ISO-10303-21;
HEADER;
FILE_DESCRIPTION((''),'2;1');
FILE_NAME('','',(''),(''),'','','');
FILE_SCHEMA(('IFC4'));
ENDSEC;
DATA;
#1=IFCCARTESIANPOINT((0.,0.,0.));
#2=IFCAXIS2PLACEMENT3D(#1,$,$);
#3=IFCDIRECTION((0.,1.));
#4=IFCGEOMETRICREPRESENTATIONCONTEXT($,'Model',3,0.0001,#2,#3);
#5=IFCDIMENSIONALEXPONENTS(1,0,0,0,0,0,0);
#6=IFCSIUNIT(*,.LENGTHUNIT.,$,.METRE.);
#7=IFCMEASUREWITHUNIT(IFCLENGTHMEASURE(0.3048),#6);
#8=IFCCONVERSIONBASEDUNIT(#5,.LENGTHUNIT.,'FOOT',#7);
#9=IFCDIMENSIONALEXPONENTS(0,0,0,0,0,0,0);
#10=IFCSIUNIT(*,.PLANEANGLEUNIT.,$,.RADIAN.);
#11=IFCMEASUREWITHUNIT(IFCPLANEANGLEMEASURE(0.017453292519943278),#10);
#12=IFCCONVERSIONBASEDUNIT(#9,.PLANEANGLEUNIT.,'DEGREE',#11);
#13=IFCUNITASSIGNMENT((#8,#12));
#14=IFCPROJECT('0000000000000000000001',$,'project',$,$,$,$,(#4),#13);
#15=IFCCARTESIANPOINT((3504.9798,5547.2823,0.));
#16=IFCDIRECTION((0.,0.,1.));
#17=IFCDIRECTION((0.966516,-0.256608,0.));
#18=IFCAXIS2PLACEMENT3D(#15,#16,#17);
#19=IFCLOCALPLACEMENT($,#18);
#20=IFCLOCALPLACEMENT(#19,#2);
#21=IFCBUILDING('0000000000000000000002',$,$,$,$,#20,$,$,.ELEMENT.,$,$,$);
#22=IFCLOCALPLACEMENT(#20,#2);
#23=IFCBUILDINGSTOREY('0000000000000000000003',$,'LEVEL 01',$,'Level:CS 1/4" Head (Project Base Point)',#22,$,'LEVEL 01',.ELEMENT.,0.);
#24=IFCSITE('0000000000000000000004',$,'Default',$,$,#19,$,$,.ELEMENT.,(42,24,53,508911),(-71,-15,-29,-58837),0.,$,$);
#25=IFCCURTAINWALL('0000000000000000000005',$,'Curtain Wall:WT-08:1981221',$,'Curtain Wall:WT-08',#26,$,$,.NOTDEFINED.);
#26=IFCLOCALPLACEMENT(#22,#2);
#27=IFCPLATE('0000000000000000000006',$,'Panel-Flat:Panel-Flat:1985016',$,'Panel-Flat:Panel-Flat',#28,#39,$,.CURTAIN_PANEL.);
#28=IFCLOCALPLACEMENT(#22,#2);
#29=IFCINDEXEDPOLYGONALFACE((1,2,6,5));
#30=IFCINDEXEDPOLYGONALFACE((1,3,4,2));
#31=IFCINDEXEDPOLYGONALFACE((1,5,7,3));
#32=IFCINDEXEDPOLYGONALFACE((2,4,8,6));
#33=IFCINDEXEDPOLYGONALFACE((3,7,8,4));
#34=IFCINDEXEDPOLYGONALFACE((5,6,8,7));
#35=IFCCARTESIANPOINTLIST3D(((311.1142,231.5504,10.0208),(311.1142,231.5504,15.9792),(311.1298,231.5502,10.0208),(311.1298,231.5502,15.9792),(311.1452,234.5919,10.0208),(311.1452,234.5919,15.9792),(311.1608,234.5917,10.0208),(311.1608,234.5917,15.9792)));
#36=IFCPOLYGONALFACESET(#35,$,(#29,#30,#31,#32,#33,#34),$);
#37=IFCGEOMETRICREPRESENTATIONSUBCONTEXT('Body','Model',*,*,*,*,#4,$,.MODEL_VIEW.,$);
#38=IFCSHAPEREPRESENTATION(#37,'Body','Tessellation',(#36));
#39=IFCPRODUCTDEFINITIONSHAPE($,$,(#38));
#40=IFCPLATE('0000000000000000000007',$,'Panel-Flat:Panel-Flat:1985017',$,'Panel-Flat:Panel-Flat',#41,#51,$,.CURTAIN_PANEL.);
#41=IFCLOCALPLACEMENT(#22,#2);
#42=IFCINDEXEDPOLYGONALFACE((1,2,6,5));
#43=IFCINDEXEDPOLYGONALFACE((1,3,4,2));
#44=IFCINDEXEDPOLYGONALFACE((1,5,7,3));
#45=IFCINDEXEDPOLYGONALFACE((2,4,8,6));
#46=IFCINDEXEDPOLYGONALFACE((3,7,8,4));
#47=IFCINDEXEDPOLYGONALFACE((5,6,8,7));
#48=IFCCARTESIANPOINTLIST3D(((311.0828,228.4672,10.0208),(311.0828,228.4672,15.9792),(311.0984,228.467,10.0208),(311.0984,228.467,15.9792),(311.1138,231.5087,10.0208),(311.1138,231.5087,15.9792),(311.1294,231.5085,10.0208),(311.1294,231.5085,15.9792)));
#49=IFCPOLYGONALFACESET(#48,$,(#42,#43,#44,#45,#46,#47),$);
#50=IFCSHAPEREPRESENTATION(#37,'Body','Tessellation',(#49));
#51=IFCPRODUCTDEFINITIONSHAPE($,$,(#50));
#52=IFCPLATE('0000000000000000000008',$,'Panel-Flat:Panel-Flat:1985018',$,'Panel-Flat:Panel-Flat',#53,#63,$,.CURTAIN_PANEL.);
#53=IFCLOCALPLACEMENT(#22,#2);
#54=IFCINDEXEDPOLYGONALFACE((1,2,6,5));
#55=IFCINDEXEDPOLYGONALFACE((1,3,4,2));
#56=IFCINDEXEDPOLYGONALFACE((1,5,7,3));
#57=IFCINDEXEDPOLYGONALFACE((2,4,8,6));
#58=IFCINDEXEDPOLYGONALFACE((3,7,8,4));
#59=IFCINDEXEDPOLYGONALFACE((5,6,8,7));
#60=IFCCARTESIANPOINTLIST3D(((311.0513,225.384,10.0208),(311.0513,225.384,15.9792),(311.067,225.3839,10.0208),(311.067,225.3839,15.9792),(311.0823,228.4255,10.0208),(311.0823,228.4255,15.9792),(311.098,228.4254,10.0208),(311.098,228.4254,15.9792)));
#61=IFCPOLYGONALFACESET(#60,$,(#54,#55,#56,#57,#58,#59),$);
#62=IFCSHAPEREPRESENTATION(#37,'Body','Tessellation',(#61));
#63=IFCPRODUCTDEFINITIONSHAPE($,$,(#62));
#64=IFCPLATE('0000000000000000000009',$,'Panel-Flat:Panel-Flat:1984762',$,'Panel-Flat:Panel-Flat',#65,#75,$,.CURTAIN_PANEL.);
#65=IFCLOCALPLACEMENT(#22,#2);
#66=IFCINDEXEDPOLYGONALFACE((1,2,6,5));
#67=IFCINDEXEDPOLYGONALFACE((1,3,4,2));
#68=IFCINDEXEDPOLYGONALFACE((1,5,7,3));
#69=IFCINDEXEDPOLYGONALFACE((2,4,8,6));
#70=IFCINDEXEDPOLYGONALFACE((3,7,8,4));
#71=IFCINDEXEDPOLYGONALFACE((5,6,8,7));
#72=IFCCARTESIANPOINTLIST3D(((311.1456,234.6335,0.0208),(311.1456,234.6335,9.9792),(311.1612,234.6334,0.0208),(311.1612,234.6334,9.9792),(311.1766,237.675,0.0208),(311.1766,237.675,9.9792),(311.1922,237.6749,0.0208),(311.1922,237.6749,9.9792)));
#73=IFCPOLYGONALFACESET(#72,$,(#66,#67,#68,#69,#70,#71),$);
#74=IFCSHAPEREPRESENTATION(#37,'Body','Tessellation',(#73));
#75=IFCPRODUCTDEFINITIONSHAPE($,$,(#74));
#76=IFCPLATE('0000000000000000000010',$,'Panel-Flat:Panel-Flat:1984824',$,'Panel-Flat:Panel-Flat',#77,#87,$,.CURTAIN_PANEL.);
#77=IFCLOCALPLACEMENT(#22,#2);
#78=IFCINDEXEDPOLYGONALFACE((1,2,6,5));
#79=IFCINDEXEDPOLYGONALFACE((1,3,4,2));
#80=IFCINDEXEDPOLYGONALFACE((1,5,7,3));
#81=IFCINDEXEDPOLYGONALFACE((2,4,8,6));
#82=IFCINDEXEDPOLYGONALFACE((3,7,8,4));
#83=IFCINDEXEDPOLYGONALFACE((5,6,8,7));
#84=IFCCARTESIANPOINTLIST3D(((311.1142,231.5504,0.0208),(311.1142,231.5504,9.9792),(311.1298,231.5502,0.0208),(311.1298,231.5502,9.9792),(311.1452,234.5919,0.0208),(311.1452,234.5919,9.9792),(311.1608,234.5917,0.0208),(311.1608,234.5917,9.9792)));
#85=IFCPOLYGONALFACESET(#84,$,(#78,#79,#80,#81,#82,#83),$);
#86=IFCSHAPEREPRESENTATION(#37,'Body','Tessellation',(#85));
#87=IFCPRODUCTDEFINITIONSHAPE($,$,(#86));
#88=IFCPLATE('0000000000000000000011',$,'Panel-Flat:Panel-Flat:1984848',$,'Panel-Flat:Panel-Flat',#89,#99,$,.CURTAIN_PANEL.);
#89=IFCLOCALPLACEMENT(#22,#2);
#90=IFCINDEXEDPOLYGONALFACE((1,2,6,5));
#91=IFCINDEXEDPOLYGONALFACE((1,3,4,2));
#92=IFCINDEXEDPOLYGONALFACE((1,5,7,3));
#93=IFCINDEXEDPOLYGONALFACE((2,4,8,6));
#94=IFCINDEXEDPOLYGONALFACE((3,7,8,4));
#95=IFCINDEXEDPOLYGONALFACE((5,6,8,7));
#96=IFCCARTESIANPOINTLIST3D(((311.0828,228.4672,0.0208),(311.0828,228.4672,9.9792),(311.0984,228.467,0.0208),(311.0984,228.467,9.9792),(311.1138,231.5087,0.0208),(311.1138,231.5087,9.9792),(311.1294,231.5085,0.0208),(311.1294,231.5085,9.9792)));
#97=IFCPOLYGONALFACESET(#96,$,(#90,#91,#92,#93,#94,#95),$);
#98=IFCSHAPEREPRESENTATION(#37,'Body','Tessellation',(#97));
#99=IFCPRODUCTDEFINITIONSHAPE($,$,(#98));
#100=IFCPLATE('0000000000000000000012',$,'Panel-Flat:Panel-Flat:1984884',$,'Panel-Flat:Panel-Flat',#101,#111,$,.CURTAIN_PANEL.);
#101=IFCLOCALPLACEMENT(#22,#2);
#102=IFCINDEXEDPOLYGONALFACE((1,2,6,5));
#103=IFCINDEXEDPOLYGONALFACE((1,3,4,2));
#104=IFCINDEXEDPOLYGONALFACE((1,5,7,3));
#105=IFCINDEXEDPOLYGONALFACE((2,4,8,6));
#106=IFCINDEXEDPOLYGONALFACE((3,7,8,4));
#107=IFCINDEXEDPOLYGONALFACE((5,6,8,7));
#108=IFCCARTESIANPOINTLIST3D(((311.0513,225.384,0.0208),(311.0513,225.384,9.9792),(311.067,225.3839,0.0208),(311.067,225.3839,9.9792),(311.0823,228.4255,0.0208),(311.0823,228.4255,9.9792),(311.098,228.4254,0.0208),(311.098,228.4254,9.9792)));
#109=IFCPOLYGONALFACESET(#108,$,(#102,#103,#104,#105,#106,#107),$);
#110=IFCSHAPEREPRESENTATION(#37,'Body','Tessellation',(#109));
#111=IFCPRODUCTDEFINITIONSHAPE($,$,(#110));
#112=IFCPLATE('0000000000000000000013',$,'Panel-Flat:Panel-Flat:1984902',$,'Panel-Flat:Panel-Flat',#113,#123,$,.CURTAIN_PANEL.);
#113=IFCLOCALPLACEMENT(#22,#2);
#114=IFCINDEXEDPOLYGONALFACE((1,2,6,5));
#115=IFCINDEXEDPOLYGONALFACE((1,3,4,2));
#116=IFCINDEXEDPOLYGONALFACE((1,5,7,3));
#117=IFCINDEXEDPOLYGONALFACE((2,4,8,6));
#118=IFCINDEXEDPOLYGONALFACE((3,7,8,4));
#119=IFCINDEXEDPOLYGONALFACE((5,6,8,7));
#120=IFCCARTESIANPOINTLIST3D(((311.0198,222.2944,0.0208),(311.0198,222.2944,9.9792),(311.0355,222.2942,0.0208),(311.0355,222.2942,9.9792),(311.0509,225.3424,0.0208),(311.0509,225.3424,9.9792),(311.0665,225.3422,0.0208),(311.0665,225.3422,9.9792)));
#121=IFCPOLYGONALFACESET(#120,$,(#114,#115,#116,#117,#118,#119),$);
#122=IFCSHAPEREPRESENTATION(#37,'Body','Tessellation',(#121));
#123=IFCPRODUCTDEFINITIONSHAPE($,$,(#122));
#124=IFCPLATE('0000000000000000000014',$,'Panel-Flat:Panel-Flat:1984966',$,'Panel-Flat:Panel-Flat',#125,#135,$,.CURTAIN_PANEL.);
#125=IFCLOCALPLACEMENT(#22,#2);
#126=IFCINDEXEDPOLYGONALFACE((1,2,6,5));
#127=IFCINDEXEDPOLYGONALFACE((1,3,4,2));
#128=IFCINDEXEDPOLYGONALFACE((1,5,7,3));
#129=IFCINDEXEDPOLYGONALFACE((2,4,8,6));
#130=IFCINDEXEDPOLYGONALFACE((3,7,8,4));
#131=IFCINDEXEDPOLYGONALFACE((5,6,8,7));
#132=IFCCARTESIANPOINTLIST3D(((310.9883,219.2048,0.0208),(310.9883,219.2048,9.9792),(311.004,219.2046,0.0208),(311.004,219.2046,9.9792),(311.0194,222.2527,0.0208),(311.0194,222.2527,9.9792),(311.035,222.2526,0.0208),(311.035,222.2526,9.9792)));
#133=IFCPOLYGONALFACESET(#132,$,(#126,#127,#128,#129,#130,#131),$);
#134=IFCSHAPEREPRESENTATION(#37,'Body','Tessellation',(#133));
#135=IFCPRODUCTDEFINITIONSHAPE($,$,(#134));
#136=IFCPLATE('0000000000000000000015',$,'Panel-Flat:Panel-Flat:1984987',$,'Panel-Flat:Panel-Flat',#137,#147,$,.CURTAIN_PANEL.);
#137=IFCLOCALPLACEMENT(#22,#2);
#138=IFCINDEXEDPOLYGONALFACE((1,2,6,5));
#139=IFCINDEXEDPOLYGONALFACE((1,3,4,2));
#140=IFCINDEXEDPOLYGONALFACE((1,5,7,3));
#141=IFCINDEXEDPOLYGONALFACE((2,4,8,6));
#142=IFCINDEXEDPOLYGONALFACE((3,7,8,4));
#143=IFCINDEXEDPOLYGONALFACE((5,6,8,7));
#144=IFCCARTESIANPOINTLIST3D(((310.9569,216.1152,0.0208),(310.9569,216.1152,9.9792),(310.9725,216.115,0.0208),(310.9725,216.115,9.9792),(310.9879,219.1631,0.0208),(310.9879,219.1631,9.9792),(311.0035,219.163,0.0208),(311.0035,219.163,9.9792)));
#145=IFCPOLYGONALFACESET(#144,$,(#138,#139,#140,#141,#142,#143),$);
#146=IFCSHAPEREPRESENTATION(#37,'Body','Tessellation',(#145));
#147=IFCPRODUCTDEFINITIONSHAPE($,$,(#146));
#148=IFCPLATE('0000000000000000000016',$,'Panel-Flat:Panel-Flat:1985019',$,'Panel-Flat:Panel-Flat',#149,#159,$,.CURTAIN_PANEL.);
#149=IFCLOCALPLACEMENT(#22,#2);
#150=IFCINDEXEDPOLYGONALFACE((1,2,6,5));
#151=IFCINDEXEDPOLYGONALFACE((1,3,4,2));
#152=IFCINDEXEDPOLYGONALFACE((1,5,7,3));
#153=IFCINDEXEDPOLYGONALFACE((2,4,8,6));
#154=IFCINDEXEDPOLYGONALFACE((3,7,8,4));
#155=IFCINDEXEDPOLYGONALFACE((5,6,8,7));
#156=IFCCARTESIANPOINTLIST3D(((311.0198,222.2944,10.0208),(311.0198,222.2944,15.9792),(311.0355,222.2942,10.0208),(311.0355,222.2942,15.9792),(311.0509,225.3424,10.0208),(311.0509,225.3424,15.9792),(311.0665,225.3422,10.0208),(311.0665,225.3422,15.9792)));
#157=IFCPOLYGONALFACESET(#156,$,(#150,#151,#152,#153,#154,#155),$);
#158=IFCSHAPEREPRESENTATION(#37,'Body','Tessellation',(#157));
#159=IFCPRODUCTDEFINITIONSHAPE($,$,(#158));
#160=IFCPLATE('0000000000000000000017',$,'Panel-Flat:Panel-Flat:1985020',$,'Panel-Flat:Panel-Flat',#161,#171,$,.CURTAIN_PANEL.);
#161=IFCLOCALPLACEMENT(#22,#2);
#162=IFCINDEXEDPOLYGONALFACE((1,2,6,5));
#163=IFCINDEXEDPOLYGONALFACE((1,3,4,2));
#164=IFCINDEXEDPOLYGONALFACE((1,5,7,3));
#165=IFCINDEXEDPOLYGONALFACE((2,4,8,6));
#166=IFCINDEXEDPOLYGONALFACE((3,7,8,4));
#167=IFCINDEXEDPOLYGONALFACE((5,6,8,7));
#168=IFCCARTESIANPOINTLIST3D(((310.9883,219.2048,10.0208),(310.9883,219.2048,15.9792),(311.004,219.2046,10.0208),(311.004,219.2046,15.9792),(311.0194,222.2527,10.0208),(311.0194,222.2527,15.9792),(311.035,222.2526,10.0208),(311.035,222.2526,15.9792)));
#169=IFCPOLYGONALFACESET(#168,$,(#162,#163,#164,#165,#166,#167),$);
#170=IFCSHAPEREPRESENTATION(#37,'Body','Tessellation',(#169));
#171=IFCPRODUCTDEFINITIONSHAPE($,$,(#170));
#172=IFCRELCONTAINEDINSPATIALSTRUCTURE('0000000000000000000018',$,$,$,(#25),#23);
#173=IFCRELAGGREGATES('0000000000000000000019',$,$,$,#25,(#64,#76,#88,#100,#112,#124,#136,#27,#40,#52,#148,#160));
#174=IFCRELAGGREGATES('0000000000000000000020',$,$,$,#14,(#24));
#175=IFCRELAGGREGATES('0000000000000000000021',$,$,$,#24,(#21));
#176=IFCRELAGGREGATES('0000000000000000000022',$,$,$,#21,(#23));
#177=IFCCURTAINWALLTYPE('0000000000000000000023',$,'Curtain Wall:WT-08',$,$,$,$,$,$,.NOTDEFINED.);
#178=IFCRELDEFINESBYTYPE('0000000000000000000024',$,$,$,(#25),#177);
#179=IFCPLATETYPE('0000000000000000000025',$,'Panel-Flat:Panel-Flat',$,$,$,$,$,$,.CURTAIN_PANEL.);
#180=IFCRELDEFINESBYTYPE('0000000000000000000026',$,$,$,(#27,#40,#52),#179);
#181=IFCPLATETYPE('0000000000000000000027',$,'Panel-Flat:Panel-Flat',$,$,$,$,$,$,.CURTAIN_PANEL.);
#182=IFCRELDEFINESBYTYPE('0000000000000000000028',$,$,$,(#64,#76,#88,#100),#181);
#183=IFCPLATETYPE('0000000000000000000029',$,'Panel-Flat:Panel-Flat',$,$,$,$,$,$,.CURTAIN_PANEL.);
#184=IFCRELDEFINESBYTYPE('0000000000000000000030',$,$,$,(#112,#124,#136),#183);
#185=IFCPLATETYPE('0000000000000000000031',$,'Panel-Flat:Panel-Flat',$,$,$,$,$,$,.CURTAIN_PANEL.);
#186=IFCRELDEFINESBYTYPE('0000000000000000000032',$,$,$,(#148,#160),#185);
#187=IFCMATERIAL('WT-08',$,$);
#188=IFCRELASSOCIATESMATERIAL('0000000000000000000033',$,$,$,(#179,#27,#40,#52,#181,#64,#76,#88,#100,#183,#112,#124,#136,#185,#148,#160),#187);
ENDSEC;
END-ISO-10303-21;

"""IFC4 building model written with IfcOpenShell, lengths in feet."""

from ifc_helpers import new_model, entity, si_unit, converted_unit, direction, frame, origin, place, context, subcontext, project, spatial, indexed_curve, outline, extrude, source, transform, mapped, material, type_object, type_shapes, element, aggregate, save


model = new_model("IFC4")

# Units and contexts
model_context = context("Model", 3, precision=0.0001, world=origin(), true_north=direction((0.0, 1.0)))
body_context = subcontext(model_context, "Body", "Model", "MODEL_VIEW")
ifc_project = project(units=[converted_unit("LENGTHUNIT", "FOOT", entity("IfcLengthMeasure", 0.3048), si_unit("LENGTHUNIT", "METRE"), dimensions=[1, 0, 0, 0, 0, 0, 0]), converted_unit("PLANEANGLEUNIT", "DEGREE", entity("IfcPlaneAngleMeasure", 0.017453292519943278), si_unit("PLANEANGLEUNIT", "RADIAN"), dimensions=[0, 0, 0, 0, 0, 0, 0])], contexts=[model_context])

# Site, building, storey
site_placement = place(None, frame((3504.9798, 5547.2823, 0.0), z_axis=(0.0, 0.0, 1.0), x_axis=(0.966516, -0.256608, 0.0)))
site = spatial("IfcSite", under=ifc_project, at=site_placement, Name="Default", CompositionType="ELEMENT", RefLatitude=(42, 24, 53, 508911), RefLongitude=(-71, -15, -29, -58837), RefElevation=0.0)
building_placement = place(site_placement, origin())
building = spatial("IfcBuilding", under=site, at=building_placement, CompositionType="ELEMENT")
storey_placement = place(building_placement, origin())
storey = spatial("IfcBuildingStorey", under=building, at=storey_placement, Name="LEVEL 01", ObjectType="Level:CS 1/4\" Head (Project Base Point)", LongName="LEVEL 01", CompositionType="ELEMENT", Elevation=0.0)

# Curtain wall, plates
curtain_wall_type_1 = type_object("IfcCurtainWallType", Name="Curtain Wall:WT-08", PredefinedType="NOTDEFINED")
curtain_wall_1_placement = place(storey_placement, origin())
curtain_wall_1 = element("IfcCurtainWall", 1, at=curtain_wall_1_placement, inside=storey, type_object=curtain_wall_type_1, Name="Curtain Wall:WT-08:1981221", ObjectType="Curtain Wall:WT-08", PredefinedType="NOTDEFINED")
ifc_material_1 = material(Name="WT-08")
plate_type_1 = type_object("IfcPlateType", Name="Panel-Flat:Panel-Flat", PredefinedType="CURTAIN_PANEL", material=ifc_material_1)
shared_shape_1 = source(origin(), body_context, "Body", "SweptSolid", [
    extrude(outline(indexed_curve([(-0.0078, -1.5208), (0.0078, -1.5208), (0.0078, 1.5208), (-0.0078, 1.5208), (-0.0078, -1.5208)], self_intersect=False)), frame((0.0, -0.0078, 0.0208), z_axis=(0.0, 0.0, 1.0), x_axis=(0.0, -1.0, 0.0)), (0.0, 0.0, 1.0), 5.9583),
])
type_shapes(plate_type_1, [shared_shape_1])
plate_1_placement = place(curtain_wall_1_placement, frame((311.1453, 233.071, 10.0), z_axis=(0.0, 0.0, 1.0), x_axis=(-0.010193, -0.999948, 0.0)))
plate_1 = element("IfcPlate", 2, at=plate_1_placement, type_object=plate_type_1, material=ifc_material_1, Name="Panel-Flat:Panel-Flat:1985016", ObjectType="Panel-Flat:Panel-Flat", PredefinedType="CURTAIN_PANEL", context=body_context, shape_type="MappedRepresentation", body=[
    mapped(shared_shape_1, transform((0.0, 0.0, 0.0), scale=1.0)),
])
plate_2_placement = place(curtain_wall_1_placement, frame((311.1139, 229.9878, 10.0), z_axis=(0.0, 0.0, 1.0), x_axis=(-0.010193, -0.999948, 0.0)))
plate_2 = element("IfcPlate", 3, at=plate_2_placement, type_object=plate_type_1, material=ifc_material_1, Name="Panel-Flat:Panel-Flat:1985017", ObjectType="Panel-Flat:Panel-Flat", PredefinedType="CURTAIN_PANEL", context=body_context, shape_type="MappedRepresentation", body=[
    mapped(shared_shape_1, transform((0.0, 0.0, 0.0), scale=1.0)),
])
plate_3_placement = place(curtain_wall_1_placement, frame((311.0825, 226.9046, 10.0), z_axis=(0.0, 0.0, 1.0), x_axis=(-0.010193, -0.999948, 0.0)))
plate_3 = element("IfcPlate", 4, at=plate_3_placement, type_object=plate_type_1, material=ifc_material_1, Name="Panel-Flat:Panel-Flat:1985018", ObjectType="Panel-Flat:Panel-Flat", PredefinedType="CURTAIN_PANEL", context=body_context, shape_type="MappedRepresentation", body=[
    mapped(shared_shape_1, transform((0.0, 0.0, 0.0), scale=1.0)),
])
plate_type_2 = type_object("IfcPlateType", Name="Panel-Flat:Panel-Flat", PredefinedType="CURTAIN_PANEL", material=ifc_material_1)
shared_shape_2 = source(origin(), body_context, "Body", "SweptSolid", [
    extrude(outline(indexed_curve([(-0.0078, -1.5208), (0.0078, -1.5208), (0.0078, 1.5208), (-0.0078, 1.5208), (-0.0078, -1.5208)], self_intersect=False)), frame((0.0, -0.0078, 0.0208), z_axis=(0.0, 0.0, 1.0), x_axis=(0.0, -1.0, 0.0)), (0.0, 0.0, 1.0), 9.9583),
])
type_shapes(plate_type_2, [shared_shape_2])
plate_4_placement = place(curtain_wall_1_placement, frame((311.1767, 236.1541, 0.0), z_axis=(0.0, 0.0, 1.0), x_axis=(-0.010193, -0.999948, 0.0)))
plate_4 = element("IfcPlate", 5, at=plate_4_placement, type_object=plate_type_2, material=ifc_material_1, Name="Panel-Flat:Panel-Flat:1984762", ObjectType="Panel-Flat:Panel-Flat", PredefinedType="CURTAIN_PANEL", context=body_context, shape_type="MappedRepresentation", body=[
    mapped(shared_shape_2, transform((0.0, 0.0, 0.0), scale=1.0)),
])
plate_5_placement = place(curtain_wall_1_placement, frame((311.1453, 233.071, 0.0), z_axis=(0.0, 0.0, 1.0), x_axis=(-0.010193, -0.999948, 0.0)))
plate_5 = element("IfcPlate", 6, at=plate_5_placement, type_object=plate_type_2, material=ifc_material_1, Name="Panel-Flat:Panel-Flat:1984824", ObjectType="Panel-Flat:Panel-Flat", PredefinedType="CURTAIN_PANEL", context=body_context, shape_type="MappedRepresentation", body=[
    mapped(shared_shape_2, transform((0.0, 0.0, 0.0), scale=1.0)),
])
plate_6_placement = place(curtain_wall_1_placement, frame((311.1139, 229.9878, 0.0), z_axis=(0.0, 0.0, 1.0), x_axis=(-0.010193, -0.999948, 0.0)))
plate_6 = element("IfcPlate", 7, at=plate_6_placement, type_object=plate_type_2, material=ifc_material_1, Name="Panel-Flat:Panel-Flat:1984848", ObjectType="Panel-Flat:Panel-Flat", PredefinedType="CURTAIN_PANEL", context=body_context, shape_type="MappedRepresentation", body=[
    mapped(shared_shape_2, transform((0.0, 0.0, 0.0), scale=1.0)),
])
plate_7_placement = place(curtain_wall_1_placement, frame((311.0825, 226.9046, 0.0), z_axis=(0.0, 0.0, 1.0), x_axis=(-0.010193, -0.999948, 0.0)))
plate_7 = element("IfcPlate", 8, at=plate_7_placement, type_object=plate_type_2, material=ifc_material_1, Name="Panel-Flat:Panel-Flat:1984884", ObjectType="Panel-Flat:Panel-Flat", PredefinedType="CURTAIN_PANEL", context=body_context, shape_type="MappedRepresentation", body=[
    mapped(shared_shape_2, transform((0.0, 0.0, 0.0), scale=1.0)),
])
plate_type_3 = type_object("IfcPlateType", Name="Panel-Flat:Panel-Flat", PredefinedType="CURTAIN_PANEL", material=ifc_material_1)
shared_shape_3 = source(origin(), body_context, "Body", "SweptSolid", [
    extrude(outline(indexed_curve([(-0.0078, -1.5241), (0.0078, -1.5241), (0.0078, 1.5241), (-0.0078, 1.5241), (-0.0078, -1.5241)], self_intersect=False)), frame((0.0, -0.0078, 0.0208), z_axis=(0.0, 0.0, 1.0), x_axis=(0.0, -1.0, 0.0)), (0.0, 0.0, 1.0), 9.9583),
])
type_shapes(plate_type_3, [shared_shape_3])
plate_8_placement = place(curtain_wall_1_placement, frame((311.051, 223.8182, 0.0), z_axis=(0.0, 0.0, 1.0), x_axis=(-0.010193, -0.999948, 0.0)))
plate_8 = element("IfcPlate", 9, at=plate_8_placement, type_object=plate_type_3, material=ifc_material_1, Name="Panel-Flat:Panel-Flat:1984902", ObjectType="Panel-Flat:Panel-Flat", PredefinedType="CURTAIN_PANEL", context=body_context, shape_type="MappedRepresentation", body=[
    mapped(shared_shape_3, transform((0.0, 0.0, 0.0), scale=1.0)),
])
plate_9_placement = place(curtain_wall_1_placement, frame((311.0195, 220.7286, 0.0), z_axis=(0.0, 0.0, 1.0), x_axis=(-0.010193, -0.999948, 0.0)))
plate_9 = element("IfcPlate", 10, at=plate_9_placement, type_object=plate_type_3, material=ifc_material_1, Name="Panel-Flat:Panel-Flat:1984966", ObjectType="Panel-Flat:Panel-Flat", PredefinedType="CURTAIN_PANEL", context=body_context, shape_type="MappedRepresentation", body=[
    mapped(shared_shape_3, transform((0.0, 0.0, 0.0), scale=1.0)),
])
plate_10_placement = place(curtain_wall_1_placement, frame((310.988, 217.639, 0.0), z_axis=(0.0, 0.0, 1.0), x_axis=(-0.010193, -0.999948, 0.0)))
plate_10 = element("IfcPlate", 11, at=plate_10_placement, type_object=plate_type_3, material=ifc_material_1, Name="Panel-Flat:Panel-Flat:1984987", ObjectType="Panel-Flat:Panel-Flat", PredefinedType="CURTAIN_PANEL", context=body_context, shape_type="MappedRepresentation", body=[
    mapped(shared_shape_3, transform((0.0, 0.0, 0.0), scale=1.0)),
])
plate_type_4 = type_object("IfcPlateType", Name="Panel-Flat:Panel-Flat", PredefinedType="CURTAIN_PANEL", material=ifc_material_1)
shared_shape_4 = source(origin(), body_context, "Body", "SweptSolid", [
    extrude(outline(indexed_curve([(-0.0078, -1.5241), (0.0078, -1.5241), (0.0078, 1.5241), (-0.0078, 1.5241), (-0.0078, -1.5241)], self_intersect=False)), frame((0.0, -0.0078, 0.0208), z_axis=(0.0, 0.0, 1.0), x_axis=(0.0, -1.0, 0.0)), (0.0, 0.0, 1.0), 5.9583),
])
type_shapes(plate_type_4, [shared_shape_4])
plate_11_placement = place(curtain_wall_1_placement, frame((311.051, 223.8182, 10.0), z_axis=(0.0, 0.0, 1.0), x_axis=(-0.010193, -0.999948, 0.0)))
plate_11 = element("IfcPlate", 12, at=plate_11_placement, type_object=plate_type_4, material=ifc_material_1, Name="Panel-Flat:Panel-Flat:1985019", ObjectType="Panel-Flat:Panel-Flat", PredefinedType="CURTAIN_PANEL", context=body_context, shape_type="MappedRepresentation", body=[
    mapped(shared_shape_4, transform((0.0, 0.0, 0.0), scale=1.0)),
])
plate_12_placement = place(curtain_wall_1_placement, frame((311.0195, 220.7286, 10.0), z_axis=(0.0, 0.0, 1.0), x_axis=(-0.010193, -0.999948, 0.0)))
plate_12 = element("IfcPlate", 13, at=plate_12_placement, type_object=plate_type_4, material=ifc_material_1, Name="Panel-Flat:Panel-Flat:1985020", ObjectType="Panel-Flat:Panel-Flat", PredefinedType="CURTAIN_PANEL", context=body_context, shape_type="MappedRepresentation", body=[
    mapped(shared_shape_4, transform((0.0, 0.0, 0.0), scale=1.0)),
])
aggregate(curtain_wall_1, [plate_4, plate_5, plate_6, plate_7, plate_8, plate_9, plate_10, plate_1, plate_2, plate_3, plate_11, plate_12])

save(model, "model.ifc")
